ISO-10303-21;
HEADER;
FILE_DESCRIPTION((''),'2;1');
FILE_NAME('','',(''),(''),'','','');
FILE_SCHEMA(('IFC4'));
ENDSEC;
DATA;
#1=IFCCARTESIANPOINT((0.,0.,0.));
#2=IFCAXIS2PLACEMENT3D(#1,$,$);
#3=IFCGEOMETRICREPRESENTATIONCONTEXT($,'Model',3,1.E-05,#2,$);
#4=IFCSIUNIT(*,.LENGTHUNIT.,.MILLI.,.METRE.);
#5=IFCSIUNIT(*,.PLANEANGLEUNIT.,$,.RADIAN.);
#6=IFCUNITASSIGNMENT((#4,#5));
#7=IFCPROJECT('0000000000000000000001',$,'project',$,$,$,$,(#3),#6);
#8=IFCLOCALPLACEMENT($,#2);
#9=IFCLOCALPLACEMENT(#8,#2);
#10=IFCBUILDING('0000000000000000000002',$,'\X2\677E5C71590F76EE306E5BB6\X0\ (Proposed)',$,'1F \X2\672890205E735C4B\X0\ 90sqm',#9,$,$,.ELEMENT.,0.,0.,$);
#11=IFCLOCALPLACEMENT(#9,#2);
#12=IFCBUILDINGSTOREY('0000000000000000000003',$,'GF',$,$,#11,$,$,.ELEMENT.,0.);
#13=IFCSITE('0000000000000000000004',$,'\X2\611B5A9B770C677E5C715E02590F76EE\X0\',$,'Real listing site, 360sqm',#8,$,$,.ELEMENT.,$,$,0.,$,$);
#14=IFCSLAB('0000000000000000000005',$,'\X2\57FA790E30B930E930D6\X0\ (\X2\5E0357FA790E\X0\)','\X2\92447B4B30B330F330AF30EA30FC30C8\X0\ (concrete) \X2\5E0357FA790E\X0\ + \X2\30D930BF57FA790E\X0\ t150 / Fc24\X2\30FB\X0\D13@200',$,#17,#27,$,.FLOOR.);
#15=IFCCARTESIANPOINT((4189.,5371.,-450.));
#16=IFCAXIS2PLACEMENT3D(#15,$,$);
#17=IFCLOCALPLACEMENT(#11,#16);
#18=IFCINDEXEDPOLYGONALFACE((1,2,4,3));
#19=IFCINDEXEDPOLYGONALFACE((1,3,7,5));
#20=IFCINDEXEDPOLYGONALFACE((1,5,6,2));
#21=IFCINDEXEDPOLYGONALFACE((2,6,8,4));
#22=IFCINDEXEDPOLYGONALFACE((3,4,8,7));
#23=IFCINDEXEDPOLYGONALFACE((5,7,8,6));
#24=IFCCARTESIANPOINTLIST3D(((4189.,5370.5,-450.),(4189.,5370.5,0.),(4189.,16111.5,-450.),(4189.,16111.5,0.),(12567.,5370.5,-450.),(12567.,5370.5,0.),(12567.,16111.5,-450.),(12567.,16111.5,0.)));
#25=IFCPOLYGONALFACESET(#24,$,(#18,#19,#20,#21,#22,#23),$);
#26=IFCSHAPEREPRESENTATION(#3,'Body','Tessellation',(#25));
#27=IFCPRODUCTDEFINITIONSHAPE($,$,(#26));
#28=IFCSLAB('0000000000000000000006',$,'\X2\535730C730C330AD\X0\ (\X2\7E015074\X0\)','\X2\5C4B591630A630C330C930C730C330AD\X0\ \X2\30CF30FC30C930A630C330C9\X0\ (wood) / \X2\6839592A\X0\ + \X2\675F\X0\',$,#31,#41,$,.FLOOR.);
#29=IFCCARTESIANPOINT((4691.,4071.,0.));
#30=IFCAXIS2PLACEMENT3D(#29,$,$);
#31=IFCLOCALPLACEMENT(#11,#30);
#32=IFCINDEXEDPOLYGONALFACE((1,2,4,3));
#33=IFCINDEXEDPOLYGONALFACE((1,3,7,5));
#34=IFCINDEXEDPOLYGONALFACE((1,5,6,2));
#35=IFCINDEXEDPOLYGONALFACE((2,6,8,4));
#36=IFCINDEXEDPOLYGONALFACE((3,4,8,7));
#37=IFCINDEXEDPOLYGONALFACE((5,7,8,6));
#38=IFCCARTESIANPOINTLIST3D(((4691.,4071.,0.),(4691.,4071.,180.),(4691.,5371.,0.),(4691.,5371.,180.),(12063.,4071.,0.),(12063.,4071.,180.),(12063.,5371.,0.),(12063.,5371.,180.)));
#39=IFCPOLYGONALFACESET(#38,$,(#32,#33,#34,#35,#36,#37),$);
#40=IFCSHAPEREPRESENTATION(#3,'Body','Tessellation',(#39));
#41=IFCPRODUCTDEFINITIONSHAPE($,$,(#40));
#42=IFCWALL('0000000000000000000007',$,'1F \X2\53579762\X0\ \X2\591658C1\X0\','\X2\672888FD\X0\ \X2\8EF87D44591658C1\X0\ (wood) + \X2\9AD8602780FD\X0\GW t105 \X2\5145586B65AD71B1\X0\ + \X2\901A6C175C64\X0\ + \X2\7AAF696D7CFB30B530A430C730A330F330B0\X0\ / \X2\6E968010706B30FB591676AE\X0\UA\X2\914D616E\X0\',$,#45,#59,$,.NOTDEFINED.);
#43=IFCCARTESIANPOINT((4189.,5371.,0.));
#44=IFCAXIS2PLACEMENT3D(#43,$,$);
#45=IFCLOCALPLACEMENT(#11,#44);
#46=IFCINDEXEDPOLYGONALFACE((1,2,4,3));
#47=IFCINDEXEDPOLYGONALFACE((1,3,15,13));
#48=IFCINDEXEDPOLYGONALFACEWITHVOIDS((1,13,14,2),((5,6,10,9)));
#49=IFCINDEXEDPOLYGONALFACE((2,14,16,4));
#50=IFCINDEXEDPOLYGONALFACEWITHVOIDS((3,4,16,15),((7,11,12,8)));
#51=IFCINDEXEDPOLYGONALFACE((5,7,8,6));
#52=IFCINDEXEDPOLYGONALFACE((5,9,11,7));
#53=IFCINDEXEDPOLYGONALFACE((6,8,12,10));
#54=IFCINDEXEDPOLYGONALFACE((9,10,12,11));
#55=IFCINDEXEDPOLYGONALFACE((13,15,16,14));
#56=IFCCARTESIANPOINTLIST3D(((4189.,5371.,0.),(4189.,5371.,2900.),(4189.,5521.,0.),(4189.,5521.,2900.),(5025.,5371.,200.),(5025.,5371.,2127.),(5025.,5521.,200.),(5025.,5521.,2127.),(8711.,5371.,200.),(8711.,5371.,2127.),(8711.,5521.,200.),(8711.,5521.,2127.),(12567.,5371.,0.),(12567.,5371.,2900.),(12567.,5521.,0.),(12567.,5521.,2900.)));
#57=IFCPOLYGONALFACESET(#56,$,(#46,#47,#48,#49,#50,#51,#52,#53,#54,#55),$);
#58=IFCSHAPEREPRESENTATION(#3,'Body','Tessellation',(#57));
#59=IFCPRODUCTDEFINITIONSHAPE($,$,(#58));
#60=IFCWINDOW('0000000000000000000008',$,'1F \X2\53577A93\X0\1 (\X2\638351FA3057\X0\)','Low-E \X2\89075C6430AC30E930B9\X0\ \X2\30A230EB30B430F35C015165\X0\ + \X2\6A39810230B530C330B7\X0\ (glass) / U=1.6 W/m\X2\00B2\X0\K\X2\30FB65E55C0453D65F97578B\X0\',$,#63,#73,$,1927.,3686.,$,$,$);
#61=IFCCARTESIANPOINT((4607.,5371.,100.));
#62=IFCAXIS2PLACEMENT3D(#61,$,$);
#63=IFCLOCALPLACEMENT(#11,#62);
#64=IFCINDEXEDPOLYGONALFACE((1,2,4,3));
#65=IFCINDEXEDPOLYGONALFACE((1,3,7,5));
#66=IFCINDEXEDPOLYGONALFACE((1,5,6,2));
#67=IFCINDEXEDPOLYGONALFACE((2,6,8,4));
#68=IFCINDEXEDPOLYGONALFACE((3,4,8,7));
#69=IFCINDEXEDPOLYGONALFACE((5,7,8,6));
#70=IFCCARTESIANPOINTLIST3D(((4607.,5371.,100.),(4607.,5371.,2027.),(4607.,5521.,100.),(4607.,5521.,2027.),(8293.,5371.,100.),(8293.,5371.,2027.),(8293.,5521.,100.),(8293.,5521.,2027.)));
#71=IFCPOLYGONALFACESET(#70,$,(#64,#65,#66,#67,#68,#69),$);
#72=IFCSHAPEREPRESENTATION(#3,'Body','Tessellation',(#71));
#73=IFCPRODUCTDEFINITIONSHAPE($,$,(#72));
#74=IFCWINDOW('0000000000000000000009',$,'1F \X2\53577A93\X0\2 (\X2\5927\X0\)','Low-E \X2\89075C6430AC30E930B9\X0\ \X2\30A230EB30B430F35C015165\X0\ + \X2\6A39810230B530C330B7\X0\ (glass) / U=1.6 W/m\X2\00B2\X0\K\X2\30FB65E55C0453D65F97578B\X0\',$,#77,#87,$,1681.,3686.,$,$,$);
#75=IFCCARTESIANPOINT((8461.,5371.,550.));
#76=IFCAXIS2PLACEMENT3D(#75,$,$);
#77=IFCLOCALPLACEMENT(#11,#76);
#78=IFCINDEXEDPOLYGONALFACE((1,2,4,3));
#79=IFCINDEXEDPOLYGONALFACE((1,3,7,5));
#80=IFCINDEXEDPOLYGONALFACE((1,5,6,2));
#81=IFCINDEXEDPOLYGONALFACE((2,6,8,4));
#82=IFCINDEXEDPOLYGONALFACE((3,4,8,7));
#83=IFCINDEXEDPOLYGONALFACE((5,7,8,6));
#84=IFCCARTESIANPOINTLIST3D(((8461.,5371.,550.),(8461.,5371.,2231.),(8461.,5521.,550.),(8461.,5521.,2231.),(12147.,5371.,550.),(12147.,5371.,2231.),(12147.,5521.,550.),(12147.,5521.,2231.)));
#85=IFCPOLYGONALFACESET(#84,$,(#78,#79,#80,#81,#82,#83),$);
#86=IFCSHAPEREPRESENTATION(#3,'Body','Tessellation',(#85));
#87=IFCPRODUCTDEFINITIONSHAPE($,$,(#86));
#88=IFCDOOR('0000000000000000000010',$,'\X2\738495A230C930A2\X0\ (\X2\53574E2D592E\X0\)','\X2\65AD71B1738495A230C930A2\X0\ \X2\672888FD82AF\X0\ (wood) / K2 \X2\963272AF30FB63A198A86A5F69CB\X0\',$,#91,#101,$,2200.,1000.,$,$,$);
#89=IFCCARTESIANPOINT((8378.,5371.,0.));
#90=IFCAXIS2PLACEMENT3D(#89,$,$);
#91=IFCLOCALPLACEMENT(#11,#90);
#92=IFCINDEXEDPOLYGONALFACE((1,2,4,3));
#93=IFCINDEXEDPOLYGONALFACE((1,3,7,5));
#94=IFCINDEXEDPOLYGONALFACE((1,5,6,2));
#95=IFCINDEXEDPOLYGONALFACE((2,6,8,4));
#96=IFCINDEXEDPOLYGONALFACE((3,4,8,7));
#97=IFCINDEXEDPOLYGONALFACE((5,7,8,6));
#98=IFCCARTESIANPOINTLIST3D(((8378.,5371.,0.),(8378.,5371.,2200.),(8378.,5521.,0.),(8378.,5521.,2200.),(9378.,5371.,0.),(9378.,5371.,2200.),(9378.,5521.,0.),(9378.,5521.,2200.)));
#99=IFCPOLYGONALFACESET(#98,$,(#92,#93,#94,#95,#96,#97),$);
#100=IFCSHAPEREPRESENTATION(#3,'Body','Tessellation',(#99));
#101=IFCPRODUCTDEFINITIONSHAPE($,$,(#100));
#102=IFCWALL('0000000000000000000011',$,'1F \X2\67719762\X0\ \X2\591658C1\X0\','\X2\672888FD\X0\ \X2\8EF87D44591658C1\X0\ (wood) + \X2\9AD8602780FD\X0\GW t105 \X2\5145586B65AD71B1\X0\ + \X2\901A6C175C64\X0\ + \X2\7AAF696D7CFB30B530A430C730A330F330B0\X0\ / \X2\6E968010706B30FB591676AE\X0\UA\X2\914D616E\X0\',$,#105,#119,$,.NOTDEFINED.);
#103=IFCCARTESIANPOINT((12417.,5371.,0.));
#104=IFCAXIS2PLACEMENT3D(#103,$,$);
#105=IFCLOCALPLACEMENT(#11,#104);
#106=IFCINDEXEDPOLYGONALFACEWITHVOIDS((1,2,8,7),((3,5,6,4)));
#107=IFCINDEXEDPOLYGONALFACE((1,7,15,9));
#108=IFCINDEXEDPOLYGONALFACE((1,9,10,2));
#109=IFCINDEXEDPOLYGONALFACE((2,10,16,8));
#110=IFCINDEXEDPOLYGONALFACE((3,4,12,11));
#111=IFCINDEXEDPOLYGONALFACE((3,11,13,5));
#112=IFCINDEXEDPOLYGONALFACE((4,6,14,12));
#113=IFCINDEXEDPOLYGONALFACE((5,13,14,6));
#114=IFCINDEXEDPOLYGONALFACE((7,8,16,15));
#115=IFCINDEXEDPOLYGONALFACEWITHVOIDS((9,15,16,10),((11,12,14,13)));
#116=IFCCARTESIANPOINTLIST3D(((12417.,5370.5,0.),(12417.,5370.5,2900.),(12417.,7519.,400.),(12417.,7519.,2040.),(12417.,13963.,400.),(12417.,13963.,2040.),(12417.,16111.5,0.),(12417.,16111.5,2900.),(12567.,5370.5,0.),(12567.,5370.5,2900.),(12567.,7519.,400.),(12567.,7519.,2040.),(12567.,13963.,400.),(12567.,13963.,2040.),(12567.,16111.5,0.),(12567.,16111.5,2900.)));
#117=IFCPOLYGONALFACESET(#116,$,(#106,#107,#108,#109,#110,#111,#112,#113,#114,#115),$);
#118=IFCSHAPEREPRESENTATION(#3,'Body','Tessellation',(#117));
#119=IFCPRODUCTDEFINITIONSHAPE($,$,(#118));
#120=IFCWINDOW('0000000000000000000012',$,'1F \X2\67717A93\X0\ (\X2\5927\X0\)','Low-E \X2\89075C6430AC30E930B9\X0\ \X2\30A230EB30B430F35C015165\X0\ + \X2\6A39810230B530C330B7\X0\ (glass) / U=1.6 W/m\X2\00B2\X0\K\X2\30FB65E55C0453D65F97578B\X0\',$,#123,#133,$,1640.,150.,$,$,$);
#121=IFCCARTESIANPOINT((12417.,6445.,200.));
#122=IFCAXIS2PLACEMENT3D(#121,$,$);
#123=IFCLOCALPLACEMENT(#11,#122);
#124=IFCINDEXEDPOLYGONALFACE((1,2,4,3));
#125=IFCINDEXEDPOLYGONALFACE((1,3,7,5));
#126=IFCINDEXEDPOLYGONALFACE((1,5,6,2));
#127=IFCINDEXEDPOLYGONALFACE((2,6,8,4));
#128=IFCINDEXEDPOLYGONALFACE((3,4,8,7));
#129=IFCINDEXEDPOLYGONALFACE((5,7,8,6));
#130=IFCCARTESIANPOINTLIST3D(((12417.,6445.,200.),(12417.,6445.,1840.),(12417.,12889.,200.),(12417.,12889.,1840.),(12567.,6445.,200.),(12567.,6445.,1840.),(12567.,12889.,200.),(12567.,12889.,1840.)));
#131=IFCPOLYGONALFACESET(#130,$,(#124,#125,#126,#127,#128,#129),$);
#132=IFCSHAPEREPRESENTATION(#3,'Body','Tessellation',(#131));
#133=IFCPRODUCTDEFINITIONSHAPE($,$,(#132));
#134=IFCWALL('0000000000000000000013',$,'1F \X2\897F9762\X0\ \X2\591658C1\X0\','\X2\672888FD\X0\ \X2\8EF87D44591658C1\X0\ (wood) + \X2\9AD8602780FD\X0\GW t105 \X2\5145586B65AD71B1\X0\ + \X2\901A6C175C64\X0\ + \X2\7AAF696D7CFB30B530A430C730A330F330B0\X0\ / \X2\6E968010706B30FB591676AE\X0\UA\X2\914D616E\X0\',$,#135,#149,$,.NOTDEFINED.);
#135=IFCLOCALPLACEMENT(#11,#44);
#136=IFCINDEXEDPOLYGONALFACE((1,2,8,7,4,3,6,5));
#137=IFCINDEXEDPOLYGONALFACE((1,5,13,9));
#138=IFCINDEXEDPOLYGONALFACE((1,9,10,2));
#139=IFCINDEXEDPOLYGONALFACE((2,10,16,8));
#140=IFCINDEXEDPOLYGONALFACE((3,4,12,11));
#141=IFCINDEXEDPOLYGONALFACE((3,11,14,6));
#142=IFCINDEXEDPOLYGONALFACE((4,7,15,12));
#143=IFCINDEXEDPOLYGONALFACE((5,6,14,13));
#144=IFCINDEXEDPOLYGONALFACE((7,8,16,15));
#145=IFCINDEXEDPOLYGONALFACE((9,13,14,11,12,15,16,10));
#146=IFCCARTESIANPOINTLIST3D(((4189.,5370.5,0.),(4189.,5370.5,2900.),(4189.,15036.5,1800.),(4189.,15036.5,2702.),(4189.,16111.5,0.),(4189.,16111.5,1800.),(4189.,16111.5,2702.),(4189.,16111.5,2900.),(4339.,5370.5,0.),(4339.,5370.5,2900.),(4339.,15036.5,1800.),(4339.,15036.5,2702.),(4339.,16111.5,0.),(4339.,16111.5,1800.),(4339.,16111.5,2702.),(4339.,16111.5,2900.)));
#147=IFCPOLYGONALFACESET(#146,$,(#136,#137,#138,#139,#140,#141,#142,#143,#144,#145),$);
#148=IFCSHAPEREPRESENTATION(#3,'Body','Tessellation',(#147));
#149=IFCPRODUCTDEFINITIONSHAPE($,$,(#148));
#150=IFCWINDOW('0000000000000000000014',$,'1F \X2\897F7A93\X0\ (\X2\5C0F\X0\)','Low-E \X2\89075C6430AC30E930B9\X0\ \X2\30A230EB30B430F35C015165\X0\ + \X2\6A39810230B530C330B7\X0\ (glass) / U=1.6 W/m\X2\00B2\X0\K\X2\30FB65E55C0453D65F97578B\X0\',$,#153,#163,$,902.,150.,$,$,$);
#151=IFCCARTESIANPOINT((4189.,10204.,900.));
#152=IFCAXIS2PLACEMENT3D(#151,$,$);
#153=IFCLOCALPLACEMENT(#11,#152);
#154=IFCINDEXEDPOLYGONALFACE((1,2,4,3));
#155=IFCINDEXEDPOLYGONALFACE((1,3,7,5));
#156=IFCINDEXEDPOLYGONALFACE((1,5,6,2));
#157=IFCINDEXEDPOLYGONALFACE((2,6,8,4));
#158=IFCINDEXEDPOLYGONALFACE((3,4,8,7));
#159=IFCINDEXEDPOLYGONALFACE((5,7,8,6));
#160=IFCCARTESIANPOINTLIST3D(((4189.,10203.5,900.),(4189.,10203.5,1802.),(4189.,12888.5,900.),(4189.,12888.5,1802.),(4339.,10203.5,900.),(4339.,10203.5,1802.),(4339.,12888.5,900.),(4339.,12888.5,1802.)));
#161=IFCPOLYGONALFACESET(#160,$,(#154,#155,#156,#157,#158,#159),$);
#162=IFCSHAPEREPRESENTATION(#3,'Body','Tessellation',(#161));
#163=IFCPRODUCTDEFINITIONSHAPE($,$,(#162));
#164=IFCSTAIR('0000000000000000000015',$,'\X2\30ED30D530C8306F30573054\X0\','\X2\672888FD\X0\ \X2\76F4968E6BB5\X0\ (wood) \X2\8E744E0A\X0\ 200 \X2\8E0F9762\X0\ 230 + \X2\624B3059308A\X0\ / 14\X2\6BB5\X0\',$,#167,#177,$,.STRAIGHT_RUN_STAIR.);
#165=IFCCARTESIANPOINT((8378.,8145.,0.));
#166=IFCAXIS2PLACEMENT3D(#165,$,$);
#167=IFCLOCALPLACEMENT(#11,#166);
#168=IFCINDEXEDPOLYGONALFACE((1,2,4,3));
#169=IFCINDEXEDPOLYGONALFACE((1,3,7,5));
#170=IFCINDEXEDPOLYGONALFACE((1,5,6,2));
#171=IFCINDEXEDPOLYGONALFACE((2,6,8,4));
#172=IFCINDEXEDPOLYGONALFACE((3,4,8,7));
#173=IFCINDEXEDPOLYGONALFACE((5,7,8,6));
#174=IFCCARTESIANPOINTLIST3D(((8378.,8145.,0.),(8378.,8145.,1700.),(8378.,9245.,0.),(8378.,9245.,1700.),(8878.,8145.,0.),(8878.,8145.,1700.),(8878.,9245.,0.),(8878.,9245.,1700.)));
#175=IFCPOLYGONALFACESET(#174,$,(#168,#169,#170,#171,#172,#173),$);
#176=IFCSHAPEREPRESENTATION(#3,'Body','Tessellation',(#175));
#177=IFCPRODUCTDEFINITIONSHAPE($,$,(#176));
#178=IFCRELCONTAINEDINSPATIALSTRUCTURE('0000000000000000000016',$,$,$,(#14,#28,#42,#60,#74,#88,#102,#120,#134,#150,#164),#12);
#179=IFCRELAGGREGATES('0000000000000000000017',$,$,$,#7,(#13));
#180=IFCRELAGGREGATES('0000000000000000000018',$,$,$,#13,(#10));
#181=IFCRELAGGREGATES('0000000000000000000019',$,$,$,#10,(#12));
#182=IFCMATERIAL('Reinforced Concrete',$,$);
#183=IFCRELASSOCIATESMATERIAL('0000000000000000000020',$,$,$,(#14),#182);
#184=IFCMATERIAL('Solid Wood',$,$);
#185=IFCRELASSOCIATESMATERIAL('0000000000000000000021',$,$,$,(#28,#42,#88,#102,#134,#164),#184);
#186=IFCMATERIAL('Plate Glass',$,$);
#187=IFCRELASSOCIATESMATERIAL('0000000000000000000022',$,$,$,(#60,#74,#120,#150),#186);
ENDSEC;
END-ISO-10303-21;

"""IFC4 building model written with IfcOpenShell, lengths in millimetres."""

from ifc_helpers import new_model, si_unit, frame, frame_2d, origin, place, context, project, spatial, rectangle, extrude, material, element, fill, save


model = new_model("IFC4")

# Units and contexts
model_context = context("Model", 3, precision=1e-05, world=origin())
ifc_project = project(units=[si_unit("LENGTHUNIT", "METRE", prefix="MILLI"), si_unit("PLANEANGLEUNIT", "RADIAN")], contexts=[model_context])

# Site, building, storey
site_placement = place(None, origin())
site = spatial("IfcSite", under=ifc_project, at=site_placement, Name="愛媛県松山市夏目", ObjectType="Real listing site, 360sqm", CompositionType="ELEMENT", RefElevation=0.0)
building_placement = place(site_placement, origin())
building = spatial("IfcBuilding", under=site, at=building_placement, Name="松山夏目の家 (Proposed)", ObjectType="1F 木造平屋 90sqm", CompositionType="ELEMENT", ElevationOfRefHeight=0.0, ElevationOfTerrain=0.0)
storey_placement = place(building_placement, origin())
storey = spatial("IfcBuildingStorey", under=building, at=storey_placement, Name="GF", CompositionType="ELEMENT", Elevation=0.0)

# Slabs
ifc_material_1 = material(Name="Reinforced Concrete")
slab_1_placement = place(storey_placement, frame((4189.0, 5371.0, -450.0)))
element("IfcSlab", 1, at=slab_1_placement, inside=storey, material=ifc_material_1, Name="基礎スラブ (布基礎)", Description="鉄筋コンクリート (concrete) 布基礎 + ベタ基礎 t150 / Fc24・D13@200", PredefinedType="FLOOR", context=model_context, shape_type="SweptSolid", body=[
    extrude(rectangle(XDim=8378.0, YDim=10741.0, at=frame_2d((4189.0, 5370.0))), frame((4189.0, 5371.0, -450.0)), (0.0, 0.0, 1.0), 450.0),
])
ifc_material_2 = material(Name="Solid Wood")
slab_2_placement = place(storey_placement, frame((4691.0, 4071.0, 0.0)))
element("IfcSlab", 2, at=slab_2_placement, inside=storey, material=ifc_material_2, Name="南デッキ (縁側)", Description="屋外ウッドデッキ ハードウッド (wood) / 根太 + 束", PredefinedType="FLOOR", context=model_context, shape_type="SweptSolid", body=[
    extrude(rectangle(XDim=7372.0, YDim=1300.0, at=frame_2d((3686.0, 650.0))), frame((4691.0, 4071.0, 0.0)), (0.0, 0.0, 1.0), 180.0),
])

# Wall, openings, windows, door
wall_1_placement = place(storey_placement, frame((4189.0, 5371.0, 0.0)))
wall_1 = element("IfcWall", 3, at=wall_1_placement, inside=storey, material=ifc_material_2, Name="1F 南面 外壁", Description="木製 軸組外壁 (wood) + 高性能GW t105 充填断熱 + 通気層 + 窯業系サイディング / 準耐火・外皮UA配慮", PredefinedType="NOTDEFINED", context=model_context, shape_type="SweptSolid", body=[
    extrude(rectangle(XDim=8378.0, YDim=150.0, at=frame_2d((4189.0, 75.0))), frame((4189.0, 5371.0, 0.0)), (0.0, 0.0, 1.0), 2900.0),
])
opening_1_placement = place(storey_placement, frame((4607.0, 5371.0, 100.0)))
opening_1 = element("IfcOpeningElement", 4, at=opening_1_placement, cuts=wall_1, PredefinedType="NOTDEFINED", context=model_context, shape_type="SweptSolid", body=[
    extrude(rectangle(XDim=3686.0, YDim=150.0, at=frame_2d((1843.0, 75.0))), frame((4607.0, 5371.0, 100.0)), (0.0, 0.0, 1.0), 1927.0),
])
opening_2_placement = place(storey_placement, frame((8461.0, 5371.0, 550.0)))
opening_2 = element("IfcOpeningElement", 5, at=opening_2_placement, cuts=wall_1, PredefinedType="NOTDEFINED", context=model_context, shape_type="SweptSolid", body=[
    extrude(rectangle(XDim=3686.0, YDim=150.0, at=frame_2d((1843.0, 75.0))), frame((8461.0, 5371.0, 550.0)), (0.0, 0.0, 1.0), 1681.0),
])
opening_3_placement = place(storey_placement, frame((8378.0, 5371.0, 0.0)))
opening_3 = element("IfcOpeningElement", 6, at=opening_3_placement, cuts=wall_1, PredefinedType="NOTDEFINED", context=model_context, shape_type="SweptSolid", body=[
    extrude(rectangle(XDim=1000.0, YDim=150.0, at=frame_2d((500.0, 75.0))), frame((8378.0, 5371.0, 0.0)), (0.0, 0.0, 1.0), 2200.0),
])
ifc_material_3 = material(Name="Plate Glass")
window_1_placement = place(storey_placement, frame((4607.0, 5371.0, 100.0)))
window_1 = element("IfcWindow", 7, at=window_1_placement, inside=storey, material=ifc_material_3, Name="1F 南窓1 (掃出し)", Description="Low-E 複層ガラス アルゴン封入 + 樹脂サッシ (glass) / U=1.6 W/m²K・日射取得型", OverallHeight=1927.0, OverallWidth=3686.0, context=model_context, shape_type="SweptSolid", body=[
    extrude(rectangle(XDim=3686.0, YDim=150.0, at=frame_2d((1843.0, 75.0))), frame((4607.0, 5371.0, 100.0)), (0.0, 0.0, 1.0), 1927.0),
])
fill(opening_1, window_1)
window_2_placement = place(storey_placement, frame((8461.0, 5371.0, 550.0)))
window_2 = element("IfcWindow", 8, at=window_2_placement, inside=storey, material=ifc_material_3, Name="1F 南窓2 (大)", Description="Low-E 複層ガラス アルゴン封入 + 樹脂サッシ (glass) / U=1.6 W/m²K・日射取得型", OverallHeight=1681.0, OverallWidth=3686.0, context=model_context, shape_type="SweptSolid", body=[
    extrude(rectangle(XDim=3686.0, YDim=150.0, at=frame_2d((1843.0, 75.0))), frame((8461.0, 5371.0, 550.0)), (0.0, 0.0, 1.0), 1681.0),
])
fill(opening_2, window_2)
door_placement = place(storey_placement, frame((8378.0, 5371.0, 0.0)))
door = element("IfcDoor", 9, at=door_placement, inside=storey, material=ifc_material_2, Name="玄関ドア (南中央)", Description="断熱玄関ドア 木製芯 (wood) / K2 防犯・採風機構", OverallHeight=2200.0, OverallWidth=1000.0, context=model_context, shape_type="SweptSolid", body=[
    extrude(rectangle(XDim=1000.0, YDim=150.0, at=frame_2d((500.0, 75.0))), frame((8378.0, 5371.0, 0.0)), (0.0, 0.0, 1.0), 2200.0),
])
fill(opening_3, door)

# Walls, openings, windows
wall_2_placement = place(storey_placement, frame((12417.0, 5371.0, 0.0)))
wall_2 = element("IfcWall", 10, at=wall_2_placement, inside=storey, material=ifc_material_2, Name="1F 東面 外壁", Description="木製 軸組外壁 (wood) + 高性能GW t105 充填断熱 + 通気層 + 窯業系サイディング / 準耐火・外皮UA配慮", PredefinedType="NOTDEFINED", context=model_context, shape_type="SweptSolid", body=[
    extrude(rectangle(XDim=150.0, YDim=10741.0, at=frame_2d((75.0, 5370.0))), frame((12417.0, 5371.0, 0.0)), (0.0, 0.0, 1.0), 2900.0),
])
opening_4_placement = place(storey_placement, frame((12417.0, 6445.0, 200.0)))
opening_4 = element("IfcOpeningElement", 11, at=opening_4_placement, cuts=wall_2, PredefinedType="NOTDEFINED", context=model_context, shape_type="SweptSolid", body=[
    extrude(rectangle(XDim=150.0, YDim=6444.0, at=frame_2d((75.0, 3222.0))), frame((12417.0, 6445.0, 200.0)), (0.0, 0.0, 1.0), 1640.0),
])
window_3_placement = place(storey_placement, frame((12417.0, 6445.0, 200.0)))
window_3 = element("IfcWindow", 12, at=window_3_placement, inside=storey, material=ifc_material_3, Name="1F 東窓 (大)", Description="Low-E 複層ガラス アルゴン封入 + 樹脂サッシ (glass) / U=1.6 W/m²K・日射取得型", OverallHeight=1640.0, OverallWidth=150.0, context=model_context, shape_type="SweptSolid", body=[
    extrude(rectangle(XDim=150.0, YDim=6444.0, at=frame_2d((75.0, 3222.0))), frame((12417.0, 6445.0, 200.0)), (0.0, 0.0, 1.0), 1640.0),
])
fill(opening_4, window_3)
wall_3_placement = place(storey_placement, frame((4189.0, 5371.0, 0.0)))
wall_3 = element("IfcWall", 13, at=wall_3_placement, inside=storey, material=ifc_material_2, Name="1F 西面 外壁", Description="木製 軸組外壁 (wood) + 高性能GW t105 充填断熱 + 通気層 + 窯業系サイディング / 準耐火・外皮UA配慮", PredefinedType="NOTDEFINED", context=model_context, shape_type="SweptSolid", body=[
    extrude(rectangle(XDim=150.0, YDim=10741.0, at=frame_2d((75.0, 5370.0))), frame((4189.0, 5371.0, 0.0)), (0.0, 0.0, 1.0), 2900.0),
])
opening_5_placement = place(storey_placement, frame((4189.0, 10204.0, 900.0)))
opening_5 = element("IfcOpeningElement", 14, at=opening_5_placement, cuts=wall_3, PredefinedType="NOTDEFINED", context=model_context, shape_type="SweptSolid", body=[
    extrude(rectangle(XDim=150.0, YDim=2685.0, at=frame_2d((75.0, 1342.0))), frame((4189.0, 10204.0, 900.0)), (0.0, 0.0, 1.0), 902.0),
])
window_4_placement = place(storey_placement, frame((4189.0, 10204.0, 900.0)))
window_4 = element("IfcWindow", 15, at=window_4_placement, inside=storey, material=ifc_material_3, Name="1F 西窓 (小)", Description="Low-E 複層ガラス アルゴン封入 + 樹脂サッシ (glass) / U=1.6 W/m²K・日射取得型", OverallHeight=902.0, OverallWidth=150.0, context=model_context, shape_type="SweptSolid", body=[
    extrude(rectangle(XDim=150.0, YDim=2685.0, at=frame_2d((75.0, 1342.0))), frame((4189.0, 10204.0, 900.0)), (0.0, 0.0, 1.0), 902.0),
])
fill(opening_5, window_4)

# Stair
stair_placement = place(storey_placement, frame((8378.0, 8145.0, 0.0)))
element("IfcStair", 16, at=stair_placement, inside=storey, material=ifc_material_2, Name="ロフトはしご", Description="木製 直階段 (wood) 蹴上 200 踏面 230 + 手すり / 14段", PredefinedType="STRAIGHT_RUN_STAIR", context=model_context, shape_type="SweptSolid", body=[
    extrude(rectangle(XDim=500.0, YDim=1100.0, at=frame_2d((250.0, 550.0))), frame((8378.0, 8145.0, 0.0)), (0.0, 0.0, 1.0), 1700.0),
])

save(model, "model.ifc")
